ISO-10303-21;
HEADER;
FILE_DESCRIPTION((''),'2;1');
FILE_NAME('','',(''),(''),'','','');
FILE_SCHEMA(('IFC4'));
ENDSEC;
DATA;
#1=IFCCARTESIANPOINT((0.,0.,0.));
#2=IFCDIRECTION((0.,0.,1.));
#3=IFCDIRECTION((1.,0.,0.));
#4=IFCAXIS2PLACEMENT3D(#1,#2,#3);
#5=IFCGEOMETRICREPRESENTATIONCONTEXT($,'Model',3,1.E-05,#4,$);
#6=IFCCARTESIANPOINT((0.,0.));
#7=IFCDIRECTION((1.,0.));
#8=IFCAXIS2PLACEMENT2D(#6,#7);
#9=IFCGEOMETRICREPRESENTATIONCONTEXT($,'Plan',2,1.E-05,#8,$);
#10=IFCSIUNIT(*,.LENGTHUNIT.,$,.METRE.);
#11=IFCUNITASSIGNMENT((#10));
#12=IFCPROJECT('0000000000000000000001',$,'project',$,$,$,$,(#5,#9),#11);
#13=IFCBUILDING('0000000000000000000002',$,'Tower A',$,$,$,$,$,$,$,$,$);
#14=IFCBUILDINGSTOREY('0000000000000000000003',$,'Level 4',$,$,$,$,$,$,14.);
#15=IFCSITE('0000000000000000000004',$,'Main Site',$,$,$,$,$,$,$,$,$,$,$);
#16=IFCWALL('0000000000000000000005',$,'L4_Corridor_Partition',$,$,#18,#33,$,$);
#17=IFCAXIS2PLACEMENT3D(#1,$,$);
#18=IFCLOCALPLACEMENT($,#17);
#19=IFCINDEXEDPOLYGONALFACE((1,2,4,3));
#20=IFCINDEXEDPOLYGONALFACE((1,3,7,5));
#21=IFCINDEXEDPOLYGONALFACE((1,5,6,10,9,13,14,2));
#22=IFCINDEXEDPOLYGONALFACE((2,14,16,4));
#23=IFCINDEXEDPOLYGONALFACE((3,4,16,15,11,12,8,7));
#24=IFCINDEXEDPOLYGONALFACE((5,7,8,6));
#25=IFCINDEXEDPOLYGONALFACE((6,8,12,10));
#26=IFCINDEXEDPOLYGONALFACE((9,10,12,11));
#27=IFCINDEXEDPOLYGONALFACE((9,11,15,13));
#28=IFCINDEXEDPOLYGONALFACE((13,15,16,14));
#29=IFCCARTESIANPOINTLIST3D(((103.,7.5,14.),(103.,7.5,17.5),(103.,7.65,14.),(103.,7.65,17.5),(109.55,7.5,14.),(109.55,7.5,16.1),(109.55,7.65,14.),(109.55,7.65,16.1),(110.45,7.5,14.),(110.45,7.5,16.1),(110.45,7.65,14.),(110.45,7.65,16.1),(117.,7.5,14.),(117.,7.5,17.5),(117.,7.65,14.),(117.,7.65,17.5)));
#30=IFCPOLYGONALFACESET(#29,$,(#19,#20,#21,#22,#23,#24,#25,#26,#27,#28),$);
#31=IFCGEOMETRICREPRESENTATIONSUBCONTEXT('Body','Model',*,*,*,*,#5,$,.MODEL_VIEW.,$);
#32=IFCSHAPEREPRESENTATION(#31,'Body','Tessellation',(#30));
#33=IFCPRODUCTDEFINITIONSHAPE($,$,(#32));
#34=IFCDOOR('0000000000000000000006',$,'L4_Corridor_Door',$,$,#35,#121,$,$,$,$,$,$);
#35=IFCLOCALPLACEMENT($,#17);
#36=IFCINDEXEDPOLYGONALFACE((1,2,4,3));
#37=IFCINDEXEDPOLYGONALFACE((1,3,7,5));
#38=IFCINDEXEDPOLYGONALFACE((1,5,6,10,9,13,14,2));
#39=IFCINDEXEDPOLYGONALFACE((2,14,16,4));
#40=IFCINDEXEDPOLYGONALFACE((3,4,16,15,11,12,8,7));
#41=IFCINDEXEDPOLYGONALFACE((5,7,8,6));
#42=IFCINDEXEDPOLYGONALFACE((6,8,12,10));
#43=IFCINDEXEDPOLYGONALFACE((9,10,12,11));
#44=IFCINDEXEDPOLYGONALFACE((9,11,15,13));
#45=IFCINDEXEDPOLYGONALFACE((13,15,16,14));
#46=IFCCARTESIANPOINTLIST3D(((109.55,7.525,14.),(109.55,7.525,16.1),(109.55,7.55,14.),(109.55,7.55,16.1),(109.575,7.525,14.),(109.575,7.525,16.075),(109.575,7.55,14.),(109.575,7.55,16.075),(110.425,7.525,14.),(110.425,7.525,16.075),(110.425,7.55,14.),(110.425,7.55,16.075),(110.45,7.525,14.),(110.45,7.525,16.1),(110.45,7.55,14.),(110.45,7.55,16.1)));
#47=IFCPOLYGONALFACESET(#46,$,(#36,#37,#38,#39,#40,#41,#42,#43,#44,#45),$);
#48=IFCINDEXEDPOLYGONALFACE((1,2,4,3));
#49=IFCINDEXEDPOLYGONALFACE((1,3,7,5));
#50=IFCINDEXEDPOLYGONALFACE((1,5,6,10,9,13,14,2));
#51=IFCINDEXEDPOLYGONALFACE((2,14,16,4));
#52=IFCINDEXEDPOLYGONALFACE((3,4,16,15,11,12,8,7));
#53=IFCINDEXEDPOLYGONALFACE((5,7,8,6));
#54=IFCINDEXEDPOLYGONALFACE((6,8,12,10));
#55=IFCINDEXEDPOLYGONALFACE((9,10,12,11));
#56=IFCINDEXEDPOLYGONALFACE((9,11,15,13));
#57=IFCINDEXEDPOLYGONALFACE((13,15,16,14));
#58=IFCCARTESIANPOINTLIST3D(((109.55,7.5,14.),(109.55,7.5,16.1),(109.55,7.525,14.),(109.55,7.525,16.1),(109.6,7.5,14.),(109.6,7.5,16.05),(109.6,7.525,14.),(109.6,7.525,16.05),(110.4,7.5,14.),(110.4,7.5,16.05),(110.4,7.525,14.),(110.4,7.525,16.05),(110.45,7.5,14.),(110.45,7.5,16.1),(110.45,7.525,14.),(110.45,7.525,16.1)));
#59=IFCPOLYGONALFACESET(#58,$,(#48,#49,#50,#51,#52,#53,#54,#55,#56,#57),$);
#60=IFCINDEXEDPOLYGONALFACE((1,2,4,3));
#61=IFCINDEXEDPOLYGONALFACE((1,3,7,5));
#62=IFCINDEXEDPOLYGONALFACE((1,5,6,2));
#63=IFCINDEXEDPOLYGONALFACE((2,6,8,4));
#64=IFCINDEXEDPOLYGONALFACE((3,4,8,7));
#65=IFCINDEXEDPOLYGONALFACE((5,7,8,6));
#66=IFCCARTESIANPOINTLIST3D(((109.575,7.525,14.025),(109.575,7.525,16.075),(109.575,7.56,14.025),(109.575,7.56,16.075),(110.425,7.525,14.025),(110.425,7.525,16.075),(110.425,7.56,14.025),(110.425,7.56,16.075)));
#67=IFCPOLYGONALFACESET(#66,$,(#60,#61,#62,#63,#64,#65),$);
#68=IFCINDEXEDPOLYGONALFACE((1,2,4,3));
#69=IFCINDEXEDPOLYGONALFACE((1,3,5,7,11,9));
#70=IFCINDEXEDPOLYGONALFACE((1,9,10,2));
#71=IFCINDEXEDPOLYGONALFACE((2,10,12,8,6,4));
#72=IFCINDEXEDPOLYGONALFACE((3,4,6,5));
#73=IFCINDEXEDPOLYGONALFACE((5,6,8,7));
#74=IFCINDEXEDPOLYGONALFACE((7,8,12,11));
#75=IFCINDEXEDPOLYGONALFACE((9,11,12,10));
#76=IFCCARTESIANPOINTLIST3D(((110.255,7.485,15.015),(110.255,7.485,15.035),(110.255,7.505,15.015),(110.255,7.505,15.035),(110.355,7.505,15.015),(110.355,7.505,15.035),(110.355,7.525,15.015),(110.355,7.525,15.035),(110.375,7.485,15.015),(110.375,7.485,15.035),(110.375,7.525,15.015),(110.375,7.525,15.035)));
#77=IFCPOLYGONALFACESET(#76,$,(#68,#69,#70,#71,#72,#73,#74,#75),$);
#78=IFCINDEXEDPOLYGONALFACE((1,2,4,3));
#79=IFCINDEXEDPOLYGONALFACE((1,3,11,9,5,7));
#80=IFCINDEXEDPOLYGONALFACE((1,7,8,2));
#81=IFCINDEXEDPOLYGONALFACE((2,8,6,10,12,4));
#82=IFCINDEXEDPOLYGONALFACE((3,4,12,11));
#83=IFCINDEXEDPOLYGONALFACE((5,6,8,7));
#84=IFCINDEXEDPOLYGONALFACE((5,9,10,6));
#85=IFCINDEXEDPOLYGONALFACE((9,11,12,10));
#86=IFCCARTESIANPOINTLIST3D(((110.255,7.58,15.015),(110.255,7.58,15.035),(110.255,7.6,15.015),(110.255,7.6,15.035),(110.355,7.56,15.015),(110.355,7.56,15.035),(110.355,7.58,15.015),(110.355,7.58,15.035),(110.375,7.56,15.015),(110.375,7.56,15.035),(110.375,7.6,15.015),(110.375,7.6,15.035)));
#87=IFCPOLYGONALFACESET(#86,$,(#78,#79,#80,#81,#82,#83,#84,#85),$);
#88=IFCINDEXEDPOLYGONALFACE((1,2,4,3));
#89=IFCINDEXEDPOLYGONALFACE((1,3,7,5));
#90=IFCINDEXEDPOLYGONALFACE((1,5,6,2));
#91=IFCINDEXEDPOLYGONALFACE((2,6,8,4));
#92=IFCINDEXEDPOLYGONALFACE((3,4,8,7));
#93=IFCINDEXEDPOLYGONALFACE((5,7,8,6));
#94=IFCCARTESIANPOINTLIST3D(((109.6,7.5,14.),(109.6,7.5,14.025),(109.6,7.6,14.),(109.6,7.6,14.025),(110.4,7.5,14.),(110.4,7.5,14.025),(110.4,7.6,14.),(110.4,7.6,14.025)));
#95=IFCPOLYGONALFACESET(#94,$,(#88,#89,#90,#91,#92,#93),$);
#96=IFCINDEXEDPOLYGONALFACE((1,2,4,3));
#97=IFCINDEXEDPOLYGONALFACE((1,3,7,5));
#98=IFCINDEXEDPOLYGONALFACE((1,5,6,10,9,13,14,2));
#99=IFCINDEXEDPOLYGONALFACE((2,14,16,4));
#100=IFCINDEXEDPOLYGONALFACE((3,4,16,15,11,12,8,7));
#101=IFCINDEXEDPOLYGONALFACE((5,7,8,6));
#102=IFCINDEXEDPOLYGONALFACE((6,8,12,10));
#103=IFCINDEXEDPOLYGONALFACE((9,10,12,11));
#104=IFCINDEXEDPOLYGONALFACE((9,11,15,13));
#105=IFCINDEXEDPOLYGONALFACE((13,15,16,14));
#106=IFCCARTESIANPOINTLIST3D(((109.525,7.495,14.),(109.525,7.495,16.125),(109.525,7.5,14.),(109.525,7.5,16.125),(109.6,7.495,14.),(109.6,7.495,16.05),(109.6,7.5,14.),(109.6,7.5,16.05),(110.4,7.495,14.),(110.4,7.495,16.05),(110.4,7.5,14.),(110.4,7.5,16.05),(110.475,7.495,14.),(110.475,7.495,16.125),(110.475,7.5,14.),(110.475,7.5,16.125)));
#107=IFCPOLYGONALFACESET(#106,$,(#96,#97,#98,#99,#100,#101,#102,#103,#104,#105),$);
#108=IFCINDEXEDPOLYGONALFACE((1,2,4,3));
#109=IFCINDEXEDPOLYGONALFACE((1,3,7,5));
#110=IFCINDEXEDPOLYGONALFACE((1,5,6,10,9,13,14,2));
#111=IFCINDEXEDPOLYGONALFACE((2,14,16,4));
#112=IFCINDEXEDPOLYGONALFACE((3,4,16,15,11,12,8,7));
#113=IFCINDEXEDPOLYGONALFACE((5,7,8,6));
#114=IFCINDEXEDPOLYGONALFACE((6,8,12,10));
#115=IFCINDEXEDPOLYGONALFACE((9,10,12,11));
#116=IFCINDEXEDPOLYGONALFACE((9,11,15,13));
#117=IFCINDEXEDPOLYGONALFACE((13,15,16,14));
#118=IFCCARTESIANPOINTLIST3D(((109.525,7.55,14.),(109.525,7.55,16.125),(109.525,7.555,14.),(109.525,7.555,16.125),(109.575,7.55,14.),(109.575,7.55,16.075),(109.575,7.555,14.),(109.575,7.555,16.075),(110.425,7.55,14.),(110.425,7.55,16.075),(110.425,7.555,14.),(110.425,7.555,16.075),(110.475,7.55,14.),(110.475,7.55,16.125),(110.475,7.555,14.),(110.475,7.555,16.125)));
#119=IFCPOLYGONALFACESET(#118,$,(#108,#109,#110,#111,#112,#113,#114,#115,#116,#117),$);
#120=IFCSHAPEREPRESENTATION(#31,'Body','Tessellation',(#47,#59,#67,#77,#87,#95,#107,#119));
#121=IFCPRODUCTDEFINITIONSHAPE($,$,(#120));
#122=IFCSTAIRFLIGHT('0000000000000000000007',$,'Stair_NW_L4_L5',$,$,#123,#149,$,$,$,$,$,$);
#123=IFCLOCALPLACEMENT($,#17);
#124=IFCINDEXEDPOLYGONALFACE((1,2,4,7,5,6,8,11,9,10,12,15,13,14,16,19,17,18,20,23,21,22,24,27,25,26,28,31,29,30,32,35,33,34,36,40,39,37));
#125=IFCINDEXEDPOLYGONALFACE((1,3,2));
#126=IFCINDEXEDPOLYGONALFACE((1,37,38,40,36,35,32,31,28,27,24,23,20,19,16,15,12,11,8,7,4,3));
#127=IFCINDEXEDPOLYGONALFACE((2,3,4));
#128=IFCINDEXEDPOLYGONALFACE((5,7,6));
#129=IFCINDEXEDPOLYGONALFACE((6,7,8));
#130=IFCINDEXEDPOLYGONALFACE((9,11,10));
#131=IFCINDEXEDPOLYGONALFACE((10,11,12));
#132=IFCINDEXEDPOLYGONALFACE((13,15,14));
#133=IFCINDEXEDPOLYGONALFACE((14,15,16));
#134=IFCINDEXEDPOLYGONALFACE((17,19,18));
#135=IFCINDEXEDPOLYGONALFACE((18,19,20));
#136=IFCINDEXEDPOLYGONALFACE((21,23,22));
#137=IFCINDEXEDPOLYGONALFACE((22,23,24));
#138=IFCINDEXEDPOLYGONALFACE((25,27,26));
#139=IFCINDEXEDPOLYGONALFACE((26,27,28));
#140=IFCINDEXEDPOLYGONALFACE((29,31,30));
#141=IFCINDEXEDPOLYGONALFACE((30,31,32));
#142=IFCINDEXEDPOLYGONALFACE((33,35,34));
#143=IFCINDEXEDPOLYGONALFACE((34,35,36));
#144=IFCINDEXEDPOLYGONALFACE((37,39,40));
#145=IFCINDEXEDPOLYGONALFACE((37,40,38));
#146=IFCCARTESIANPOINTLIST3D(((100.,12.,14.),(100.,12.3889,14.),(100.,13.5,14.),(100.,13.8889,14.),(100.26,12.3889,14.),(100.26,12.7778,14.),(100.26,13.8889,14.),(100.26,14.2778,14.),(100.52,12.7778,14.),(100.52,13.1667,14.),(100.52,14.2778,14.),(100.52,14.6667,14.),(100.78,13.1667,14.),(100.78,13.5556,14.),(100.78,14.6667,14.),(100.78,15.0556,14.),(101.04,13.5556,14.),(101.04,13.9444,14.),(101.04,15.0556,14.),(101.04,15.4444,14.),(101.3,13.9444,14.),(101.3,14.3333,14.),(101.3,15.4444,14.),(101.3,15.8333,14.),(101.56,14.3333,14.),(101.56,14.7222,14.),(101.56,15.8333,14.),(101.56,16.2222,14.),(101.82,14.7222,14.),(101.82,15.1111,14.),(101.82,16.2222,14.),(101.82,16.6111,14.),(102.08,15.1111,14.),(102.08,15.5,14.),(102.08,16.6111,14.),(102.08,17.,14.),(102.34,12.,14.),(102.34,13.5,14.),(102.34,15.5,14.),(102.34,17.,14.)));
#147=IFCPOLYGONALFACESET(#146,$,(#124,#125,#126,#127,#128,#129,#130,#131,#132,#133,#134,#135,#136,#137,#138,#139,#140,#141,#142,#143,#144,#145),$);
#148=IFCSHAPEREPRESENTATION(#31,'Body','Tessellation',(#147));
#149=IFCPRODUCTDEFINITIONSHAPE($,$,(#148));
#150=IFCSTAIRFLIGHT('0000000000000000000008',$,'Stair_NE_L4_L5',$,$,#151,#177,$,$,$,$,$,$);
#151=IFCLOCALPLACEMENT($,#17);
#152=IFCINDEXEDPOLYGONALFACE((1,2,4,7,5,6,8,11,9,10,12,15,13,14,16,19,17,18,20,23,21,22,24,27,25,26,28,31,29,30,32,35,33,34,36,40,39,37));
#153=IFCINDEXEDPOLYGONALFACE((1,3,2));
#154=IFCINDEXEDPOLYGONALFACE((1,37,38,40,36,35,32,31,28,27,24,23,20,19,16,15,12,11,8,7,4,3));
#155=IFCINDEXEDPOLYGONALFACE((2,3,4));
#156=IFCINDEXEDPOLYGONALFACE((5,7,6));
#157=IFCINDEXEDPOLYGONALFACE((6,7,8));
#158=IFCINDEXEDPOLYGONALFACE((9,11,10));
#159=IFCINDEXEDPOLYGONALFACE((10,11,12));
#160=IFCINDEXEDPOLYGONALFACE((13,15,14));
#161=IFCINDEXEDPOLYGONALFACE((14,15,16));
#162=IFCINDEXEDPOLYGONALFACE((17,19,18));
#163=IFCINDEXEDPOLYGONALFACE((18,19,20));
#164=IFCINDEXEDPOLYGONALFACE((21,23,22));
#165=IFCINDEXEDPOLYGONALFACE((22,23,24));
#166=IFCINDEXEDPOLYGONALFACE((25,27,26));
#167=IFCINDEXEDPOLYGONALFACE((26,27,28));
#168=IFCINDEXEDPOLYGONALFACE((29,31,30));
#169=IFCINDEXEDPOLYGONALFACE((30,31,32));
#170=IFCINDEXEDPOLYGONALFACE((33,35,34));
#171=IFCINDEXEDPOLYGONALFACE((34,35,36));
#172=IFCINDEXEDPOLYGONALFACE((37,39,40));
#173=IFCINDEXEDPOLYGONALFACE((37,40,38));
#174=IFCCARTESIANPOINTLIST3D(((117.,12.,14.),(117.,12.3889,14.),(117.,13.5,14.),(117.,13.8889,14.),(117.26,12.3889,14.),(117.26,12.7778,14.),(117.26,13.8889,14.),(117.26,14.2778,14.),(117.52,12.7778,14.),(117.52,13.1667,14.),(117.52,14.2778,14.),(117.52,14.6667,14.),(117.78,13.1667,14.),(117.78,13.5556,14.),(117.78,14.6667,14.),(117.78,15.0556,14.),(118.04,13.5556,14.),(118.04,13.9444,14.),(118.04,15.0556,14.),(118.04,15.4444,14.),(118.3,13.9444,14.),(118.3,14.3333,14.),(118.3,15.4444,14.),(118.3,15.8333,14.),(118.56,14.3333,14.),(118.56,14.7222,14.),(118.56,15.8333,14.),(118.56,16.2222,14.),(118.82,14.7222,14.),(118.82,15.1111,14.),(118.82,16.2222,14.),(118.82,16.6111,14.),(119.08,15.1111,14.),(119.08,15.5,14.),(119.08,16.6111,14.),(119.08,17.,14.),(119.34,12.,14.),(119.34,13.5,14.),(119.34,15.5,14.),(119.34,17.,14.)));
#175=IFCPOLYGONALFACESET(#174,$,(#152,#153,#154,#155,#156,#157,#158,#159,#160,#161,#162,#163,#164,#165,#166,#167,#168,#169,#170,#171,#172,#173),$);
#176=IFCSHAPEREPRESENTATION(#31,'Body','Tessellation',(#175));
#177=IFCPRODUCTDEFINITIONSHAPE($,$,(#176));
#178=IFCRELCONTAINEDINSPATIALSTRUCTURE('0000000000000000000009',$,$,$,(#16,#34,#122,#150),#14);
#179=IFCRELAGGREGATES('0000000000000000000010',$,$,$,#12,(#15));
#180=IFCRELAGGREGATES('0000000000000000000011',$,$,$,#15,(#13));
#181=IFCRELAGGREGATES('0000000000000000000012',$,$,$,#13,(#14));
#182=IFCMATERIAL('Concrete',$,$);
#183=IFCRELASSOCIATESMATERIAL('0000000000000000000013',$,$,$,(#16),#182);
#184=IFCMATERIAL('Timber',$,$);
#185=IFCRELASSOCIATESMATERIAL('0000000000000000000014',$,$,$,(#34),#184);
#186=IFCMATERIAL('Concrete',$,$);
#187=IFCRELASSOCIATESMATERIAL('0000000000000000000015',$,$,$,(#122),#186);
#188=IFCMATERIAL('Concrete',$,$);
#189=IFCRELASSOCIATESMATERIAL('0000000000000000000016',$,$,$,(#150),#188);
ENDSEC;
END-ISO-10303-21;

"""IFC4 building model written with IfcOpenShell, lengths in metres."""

from ifc_helpers import new_model, si_unit, frame, origin_with_axes, origin_2d_with_axis, place, context, subcontext, project, spatial, line, indexed_curve, outline, extrude, material, element, fill, save


model = new_model("IFC4")

# Units and contexts
model_context = context("Model", 3, precision=1e-05, world=origin_with_axes())
plan_context = context("Plan", 2, precision=1e-05, world=origin_2d_with_axis())
body_context = subcontext(model_context, "Body", "Model", "MODEL_VIEW")
ifc_project = project(units=[si_unit("LENGTHUNIT", "METRE")], contexts=[model_context, plan_context])

# Site, building, storey
site = spatial("IfcSite", under=ifc_project, Name="Main Site")
building = spatial("IfcBuilding", under=site, Name="Tower A")
storey = spatial("IfcBuildingStorey", under=building, Name="Level 4", Elevation=14.0)

# Wall, opening, door
ifc_material_1 = material(Name="Concrete")
wall_1_placement = place(None, frame((103.0, 7.5, 14.0), z_axis=(0.0, 0.0, 1.0), x_axis=(1.0, 0.0, 0.0)))
wall_1 = element("IfcWall", 1, at=wall_1_placement, inside=storey, material=ifc_material_1, Name="L4_Corridor_Partition", context=body_context, shape_type="SweptSolid", body=[
    extrude(outline(indexed_curve([(0.0, 0.0), (0.0, 0.15), (14.0, 0.15), (14.0, 0.0), (0.0, 0.0)], self_intersect=False)), origin_with_axes(), (0.0, 0.0, 1.0), 3.5),
])
opening_1_placement = place(wall_1_placement, frame((6.55, 0.0, 0.0), z_axis=(0.0, 0.0, 1.0), x_axis=(1.0, 0.0, 0.0)))
opening_1 = element("IfcOpeningElement", 2, at=opening_1_placement, cuts=wall_1, context=body_context, shape_type="SweptSolid", body=[
    extrude(outline(indexed_curve([(0.0, 0.0), (0.0, 0.2), (0.9, 0.2), (0.9, 0.0), (0.0, 0.0)], self_intersect=False)), origin_with_axes(), (0.0, 0.0, 1.0), 2.1),
])
ifc_material_2 = material(Name="Timber")
door_placement = place(None, frame((109.55, 7.5, 14.0), z_axis=(0.0, 0.0, 1.0), x_axis=(1.0, 0.0, 0.0)))
door = element("IfcDoor", 3, at=door_placement, inside=storey, material=ifc_material_2, Name="L4_Corridor_Door", context=body_context, shape_type="SweptSolid", body=[
    extrude(outline(indexed_curve([(0.0, 0.0), (0.0, 2.1), (0.9, 2.1), (0.9, 0.0), (0.875, 0.0), (0.875, 2.075), (0.025, 2.075), (0.025, 0.0)], segments=[line(1, 2, 3, 4, 5, 6, 7, 8, 1)])), frame((0.0, 0.025, 0.0), z_axis=(0.0, -1.0, 0.0), x_axis=(1.0, 0.0, 0.0)), (0.0, 0.0, -1.0), 0.025),
    extrude(outline(indexed_curve([(0.0, 0.0), (0.0, 2.1), (0.9, 2.1), (0.9, 0.0), (0.85, 0.0), (0.85, 2.05), (0.05, 2.05), (0.05, 0.0)], segments=[line(1, 2, 3, 4, 5, 6, 7, 8, 1)])), frame((0.0, 0.0, 0.0), z_axis=(0.0, -1.0, 0.0), x_axis=(1.0, 0.0, 0.0)), (0.0, 0.0, -1.0), 0.025),
    extrude(outline(indexed_curve([(0.0, 0.0), (0.85, 0.0), (0.85, 0.035), (0.0, 0.035)], segments=[line(1, 2, 3, 4, 1)])), frame((0.025, 0.025, 0.025), z_axis=(0.0, 0.0, 1.0), x_axis=(1.0, 0.0, 0.0)), (0.0, 0.0, 1.0), 2.05),
    extrude(outline(indexed_curve([(0.0, 0.0), (0.0, -0.04), (-0.12, -0.04), (-0.12, -0.02), (-0.02, -0.02), (-0.02, 0.0)], segments=[line(1, 2, 3, 4, 5, 6, 1)])), frame((0.825, 0.025, 1.015), z_axis=(0.0, 0.0, 1.0), x_axis=(1.0, 0.0, 0.0)), (0.0, 0.0, 1.0), 0.02),
    extrude(outline(indexed_curve([(0.0, 0.0), (0.0, 0.04), (-0.12, 0.04), (-0.12, 0.02), (-0.02, 0.02), (-0.02, 0.0)], segments=[line(1, 2, 3, 4, 5, 6, 1)])), frame((0.825, 0.06, 1.015), z_axis=(0.0, 0.0, 1.0), x_axis=(1.0, 0.0, 0.0)), (0.0, 0.0, 1.0), 0.02),
    extrude(outline(indexed_curve([(0.0, 0.0), (0.8, 0.0), (0.8, 0.1), (0.0, 0.1)], segments=[line(1, 2, 3, 4, 1)])), frame((0.05, 0.0, 0.0), z_axis=(0.0, 0.0, 1.0), x_axis=(1.0, 0.0, 0.0)), (0.0, 0.0, 1.0), 0.025),
    extrude(outline(indexed_curve([(0.0, 0.0), (0.0, 2.125), (0.95, 2.125), (0.95, 0.0), (0.875, 0.0), (0.875, 2.05), (0.075, 2.05), (0.075, 0.0)], segments=[line(1, 2, 3, 4, 5, 6, 7, 8, 1)])), frame((-0.025, -0.005, 0.0), z_axis=(0.0, -1.0, 0.0), x_axis=(1.0, 0.0, 0.0)), (0.0, 0.0, -1.0), 0.005),
    extrude(outline(indexed_curve([(0.0, 0.0), (0.0, 2.125), (0.95, 2.125), (0.95, 0.0), (0.9, 0.0), (0.9, 2.075), (0.05, 2.075), (0.05, 0.0)], segments=[line(1, 2, 3, 4, 5, 6, 7, 8, 1)])), frame((-0.025, 0.05, 0.0), z_axis=(0.0, -1.0, 0.0), x_axis=(1.0, 0.0, 0.0)), (0.0, 0.0, -1.0), 0.005),
])
fill(opening_1, door)

# Stair flights
ifc_material_3 = material(Name="Concrete")
stair_flight_1_placement = place(None, frame((100.0, 12.0, 14.0), z_axis=(0.0, 0.0, 1.0), x_axis=(1.0, 0.0, 0.0)))
element("IfcStairFlight", 4, at=stair_flight_1_placement, inside=storey, material=ifc_material_3, Name="Stair_NW_L4_L5", context=body_context, shape_type="SweptSolid", body=[
    extrude(outline(indexed_curve([(0.0, 0.0), (0.0, 0.3889), (0.26, 0.3889), (0.26, 0.7778), (0.52, 0.7778), (0.52, 1.1667), (0.78, 1.1667), (0.78, 1.5556), (1.04, 1.5556), (1.04, 1.9444), (1.3, 1.9444), (1.3, 2.3333), (1.56, 2.3333), (1.56, 2.7222), (1.82, 2.7222), (1.82, 3.1111), (2.08, 3.1111), (2.08, 3.5), (2.34, 3.5), (2.34, 0.0)], segments=[line(1, 2, 3, 4, 5, 6, 7, 8, 9, 10, 11, 12, 13, 14, 15, 16, 17, 18, 19, 20, 1)])), origin_with_axes(), (0.0, 1.0, 0.0), 1.5),
])
ifc_material_4 = material(Name="Concrete")
stair_flight_2_placement = place(None, frame((117.0, 12.0, 14.0), z_axis=(0.0, 0.0, 1.0), x_axis=(1.0, 0.0, 0.0)))
element("IfcStairFlight", 5, at=stair_flight_2_placement, inside=storey, material=ifc_material_4, Name="Stair_NE_L4_L5", context=body_context, shape_type="SweptSolid", body=[
    extrude(outline(indexed_curve([(0.0, 0.0), (0.0, 0.3889), (0.26, 0.3889), (0.26, 0.7778), (0.52, 0.7778), (0.52, 1.1667), (0.78, 1.1667), (0.78, 1.5556), (1.04, 1.5556), (1.04, 1.9444), (1.3, 1.9444), (1.3, 2.3333), (1.56, 2.3333), (1.56, 2.7222), (1.82, 2.7222), (1.82, 3.1111), (2.08, 3.1111), (2.08, 3.5), (2.34, 3.5), (2.34, 0.0)], segments=[line(1, 2, 3, 4, 5, 6, 7, 8, 9, 10, 11, 12, 13, 14, 15, 16, 17, 18, 19, 20, 1)])), origin_with_axes(), (0.0, 1.0, 0.0), 1.5),
])

save(model, "model.ifc")
